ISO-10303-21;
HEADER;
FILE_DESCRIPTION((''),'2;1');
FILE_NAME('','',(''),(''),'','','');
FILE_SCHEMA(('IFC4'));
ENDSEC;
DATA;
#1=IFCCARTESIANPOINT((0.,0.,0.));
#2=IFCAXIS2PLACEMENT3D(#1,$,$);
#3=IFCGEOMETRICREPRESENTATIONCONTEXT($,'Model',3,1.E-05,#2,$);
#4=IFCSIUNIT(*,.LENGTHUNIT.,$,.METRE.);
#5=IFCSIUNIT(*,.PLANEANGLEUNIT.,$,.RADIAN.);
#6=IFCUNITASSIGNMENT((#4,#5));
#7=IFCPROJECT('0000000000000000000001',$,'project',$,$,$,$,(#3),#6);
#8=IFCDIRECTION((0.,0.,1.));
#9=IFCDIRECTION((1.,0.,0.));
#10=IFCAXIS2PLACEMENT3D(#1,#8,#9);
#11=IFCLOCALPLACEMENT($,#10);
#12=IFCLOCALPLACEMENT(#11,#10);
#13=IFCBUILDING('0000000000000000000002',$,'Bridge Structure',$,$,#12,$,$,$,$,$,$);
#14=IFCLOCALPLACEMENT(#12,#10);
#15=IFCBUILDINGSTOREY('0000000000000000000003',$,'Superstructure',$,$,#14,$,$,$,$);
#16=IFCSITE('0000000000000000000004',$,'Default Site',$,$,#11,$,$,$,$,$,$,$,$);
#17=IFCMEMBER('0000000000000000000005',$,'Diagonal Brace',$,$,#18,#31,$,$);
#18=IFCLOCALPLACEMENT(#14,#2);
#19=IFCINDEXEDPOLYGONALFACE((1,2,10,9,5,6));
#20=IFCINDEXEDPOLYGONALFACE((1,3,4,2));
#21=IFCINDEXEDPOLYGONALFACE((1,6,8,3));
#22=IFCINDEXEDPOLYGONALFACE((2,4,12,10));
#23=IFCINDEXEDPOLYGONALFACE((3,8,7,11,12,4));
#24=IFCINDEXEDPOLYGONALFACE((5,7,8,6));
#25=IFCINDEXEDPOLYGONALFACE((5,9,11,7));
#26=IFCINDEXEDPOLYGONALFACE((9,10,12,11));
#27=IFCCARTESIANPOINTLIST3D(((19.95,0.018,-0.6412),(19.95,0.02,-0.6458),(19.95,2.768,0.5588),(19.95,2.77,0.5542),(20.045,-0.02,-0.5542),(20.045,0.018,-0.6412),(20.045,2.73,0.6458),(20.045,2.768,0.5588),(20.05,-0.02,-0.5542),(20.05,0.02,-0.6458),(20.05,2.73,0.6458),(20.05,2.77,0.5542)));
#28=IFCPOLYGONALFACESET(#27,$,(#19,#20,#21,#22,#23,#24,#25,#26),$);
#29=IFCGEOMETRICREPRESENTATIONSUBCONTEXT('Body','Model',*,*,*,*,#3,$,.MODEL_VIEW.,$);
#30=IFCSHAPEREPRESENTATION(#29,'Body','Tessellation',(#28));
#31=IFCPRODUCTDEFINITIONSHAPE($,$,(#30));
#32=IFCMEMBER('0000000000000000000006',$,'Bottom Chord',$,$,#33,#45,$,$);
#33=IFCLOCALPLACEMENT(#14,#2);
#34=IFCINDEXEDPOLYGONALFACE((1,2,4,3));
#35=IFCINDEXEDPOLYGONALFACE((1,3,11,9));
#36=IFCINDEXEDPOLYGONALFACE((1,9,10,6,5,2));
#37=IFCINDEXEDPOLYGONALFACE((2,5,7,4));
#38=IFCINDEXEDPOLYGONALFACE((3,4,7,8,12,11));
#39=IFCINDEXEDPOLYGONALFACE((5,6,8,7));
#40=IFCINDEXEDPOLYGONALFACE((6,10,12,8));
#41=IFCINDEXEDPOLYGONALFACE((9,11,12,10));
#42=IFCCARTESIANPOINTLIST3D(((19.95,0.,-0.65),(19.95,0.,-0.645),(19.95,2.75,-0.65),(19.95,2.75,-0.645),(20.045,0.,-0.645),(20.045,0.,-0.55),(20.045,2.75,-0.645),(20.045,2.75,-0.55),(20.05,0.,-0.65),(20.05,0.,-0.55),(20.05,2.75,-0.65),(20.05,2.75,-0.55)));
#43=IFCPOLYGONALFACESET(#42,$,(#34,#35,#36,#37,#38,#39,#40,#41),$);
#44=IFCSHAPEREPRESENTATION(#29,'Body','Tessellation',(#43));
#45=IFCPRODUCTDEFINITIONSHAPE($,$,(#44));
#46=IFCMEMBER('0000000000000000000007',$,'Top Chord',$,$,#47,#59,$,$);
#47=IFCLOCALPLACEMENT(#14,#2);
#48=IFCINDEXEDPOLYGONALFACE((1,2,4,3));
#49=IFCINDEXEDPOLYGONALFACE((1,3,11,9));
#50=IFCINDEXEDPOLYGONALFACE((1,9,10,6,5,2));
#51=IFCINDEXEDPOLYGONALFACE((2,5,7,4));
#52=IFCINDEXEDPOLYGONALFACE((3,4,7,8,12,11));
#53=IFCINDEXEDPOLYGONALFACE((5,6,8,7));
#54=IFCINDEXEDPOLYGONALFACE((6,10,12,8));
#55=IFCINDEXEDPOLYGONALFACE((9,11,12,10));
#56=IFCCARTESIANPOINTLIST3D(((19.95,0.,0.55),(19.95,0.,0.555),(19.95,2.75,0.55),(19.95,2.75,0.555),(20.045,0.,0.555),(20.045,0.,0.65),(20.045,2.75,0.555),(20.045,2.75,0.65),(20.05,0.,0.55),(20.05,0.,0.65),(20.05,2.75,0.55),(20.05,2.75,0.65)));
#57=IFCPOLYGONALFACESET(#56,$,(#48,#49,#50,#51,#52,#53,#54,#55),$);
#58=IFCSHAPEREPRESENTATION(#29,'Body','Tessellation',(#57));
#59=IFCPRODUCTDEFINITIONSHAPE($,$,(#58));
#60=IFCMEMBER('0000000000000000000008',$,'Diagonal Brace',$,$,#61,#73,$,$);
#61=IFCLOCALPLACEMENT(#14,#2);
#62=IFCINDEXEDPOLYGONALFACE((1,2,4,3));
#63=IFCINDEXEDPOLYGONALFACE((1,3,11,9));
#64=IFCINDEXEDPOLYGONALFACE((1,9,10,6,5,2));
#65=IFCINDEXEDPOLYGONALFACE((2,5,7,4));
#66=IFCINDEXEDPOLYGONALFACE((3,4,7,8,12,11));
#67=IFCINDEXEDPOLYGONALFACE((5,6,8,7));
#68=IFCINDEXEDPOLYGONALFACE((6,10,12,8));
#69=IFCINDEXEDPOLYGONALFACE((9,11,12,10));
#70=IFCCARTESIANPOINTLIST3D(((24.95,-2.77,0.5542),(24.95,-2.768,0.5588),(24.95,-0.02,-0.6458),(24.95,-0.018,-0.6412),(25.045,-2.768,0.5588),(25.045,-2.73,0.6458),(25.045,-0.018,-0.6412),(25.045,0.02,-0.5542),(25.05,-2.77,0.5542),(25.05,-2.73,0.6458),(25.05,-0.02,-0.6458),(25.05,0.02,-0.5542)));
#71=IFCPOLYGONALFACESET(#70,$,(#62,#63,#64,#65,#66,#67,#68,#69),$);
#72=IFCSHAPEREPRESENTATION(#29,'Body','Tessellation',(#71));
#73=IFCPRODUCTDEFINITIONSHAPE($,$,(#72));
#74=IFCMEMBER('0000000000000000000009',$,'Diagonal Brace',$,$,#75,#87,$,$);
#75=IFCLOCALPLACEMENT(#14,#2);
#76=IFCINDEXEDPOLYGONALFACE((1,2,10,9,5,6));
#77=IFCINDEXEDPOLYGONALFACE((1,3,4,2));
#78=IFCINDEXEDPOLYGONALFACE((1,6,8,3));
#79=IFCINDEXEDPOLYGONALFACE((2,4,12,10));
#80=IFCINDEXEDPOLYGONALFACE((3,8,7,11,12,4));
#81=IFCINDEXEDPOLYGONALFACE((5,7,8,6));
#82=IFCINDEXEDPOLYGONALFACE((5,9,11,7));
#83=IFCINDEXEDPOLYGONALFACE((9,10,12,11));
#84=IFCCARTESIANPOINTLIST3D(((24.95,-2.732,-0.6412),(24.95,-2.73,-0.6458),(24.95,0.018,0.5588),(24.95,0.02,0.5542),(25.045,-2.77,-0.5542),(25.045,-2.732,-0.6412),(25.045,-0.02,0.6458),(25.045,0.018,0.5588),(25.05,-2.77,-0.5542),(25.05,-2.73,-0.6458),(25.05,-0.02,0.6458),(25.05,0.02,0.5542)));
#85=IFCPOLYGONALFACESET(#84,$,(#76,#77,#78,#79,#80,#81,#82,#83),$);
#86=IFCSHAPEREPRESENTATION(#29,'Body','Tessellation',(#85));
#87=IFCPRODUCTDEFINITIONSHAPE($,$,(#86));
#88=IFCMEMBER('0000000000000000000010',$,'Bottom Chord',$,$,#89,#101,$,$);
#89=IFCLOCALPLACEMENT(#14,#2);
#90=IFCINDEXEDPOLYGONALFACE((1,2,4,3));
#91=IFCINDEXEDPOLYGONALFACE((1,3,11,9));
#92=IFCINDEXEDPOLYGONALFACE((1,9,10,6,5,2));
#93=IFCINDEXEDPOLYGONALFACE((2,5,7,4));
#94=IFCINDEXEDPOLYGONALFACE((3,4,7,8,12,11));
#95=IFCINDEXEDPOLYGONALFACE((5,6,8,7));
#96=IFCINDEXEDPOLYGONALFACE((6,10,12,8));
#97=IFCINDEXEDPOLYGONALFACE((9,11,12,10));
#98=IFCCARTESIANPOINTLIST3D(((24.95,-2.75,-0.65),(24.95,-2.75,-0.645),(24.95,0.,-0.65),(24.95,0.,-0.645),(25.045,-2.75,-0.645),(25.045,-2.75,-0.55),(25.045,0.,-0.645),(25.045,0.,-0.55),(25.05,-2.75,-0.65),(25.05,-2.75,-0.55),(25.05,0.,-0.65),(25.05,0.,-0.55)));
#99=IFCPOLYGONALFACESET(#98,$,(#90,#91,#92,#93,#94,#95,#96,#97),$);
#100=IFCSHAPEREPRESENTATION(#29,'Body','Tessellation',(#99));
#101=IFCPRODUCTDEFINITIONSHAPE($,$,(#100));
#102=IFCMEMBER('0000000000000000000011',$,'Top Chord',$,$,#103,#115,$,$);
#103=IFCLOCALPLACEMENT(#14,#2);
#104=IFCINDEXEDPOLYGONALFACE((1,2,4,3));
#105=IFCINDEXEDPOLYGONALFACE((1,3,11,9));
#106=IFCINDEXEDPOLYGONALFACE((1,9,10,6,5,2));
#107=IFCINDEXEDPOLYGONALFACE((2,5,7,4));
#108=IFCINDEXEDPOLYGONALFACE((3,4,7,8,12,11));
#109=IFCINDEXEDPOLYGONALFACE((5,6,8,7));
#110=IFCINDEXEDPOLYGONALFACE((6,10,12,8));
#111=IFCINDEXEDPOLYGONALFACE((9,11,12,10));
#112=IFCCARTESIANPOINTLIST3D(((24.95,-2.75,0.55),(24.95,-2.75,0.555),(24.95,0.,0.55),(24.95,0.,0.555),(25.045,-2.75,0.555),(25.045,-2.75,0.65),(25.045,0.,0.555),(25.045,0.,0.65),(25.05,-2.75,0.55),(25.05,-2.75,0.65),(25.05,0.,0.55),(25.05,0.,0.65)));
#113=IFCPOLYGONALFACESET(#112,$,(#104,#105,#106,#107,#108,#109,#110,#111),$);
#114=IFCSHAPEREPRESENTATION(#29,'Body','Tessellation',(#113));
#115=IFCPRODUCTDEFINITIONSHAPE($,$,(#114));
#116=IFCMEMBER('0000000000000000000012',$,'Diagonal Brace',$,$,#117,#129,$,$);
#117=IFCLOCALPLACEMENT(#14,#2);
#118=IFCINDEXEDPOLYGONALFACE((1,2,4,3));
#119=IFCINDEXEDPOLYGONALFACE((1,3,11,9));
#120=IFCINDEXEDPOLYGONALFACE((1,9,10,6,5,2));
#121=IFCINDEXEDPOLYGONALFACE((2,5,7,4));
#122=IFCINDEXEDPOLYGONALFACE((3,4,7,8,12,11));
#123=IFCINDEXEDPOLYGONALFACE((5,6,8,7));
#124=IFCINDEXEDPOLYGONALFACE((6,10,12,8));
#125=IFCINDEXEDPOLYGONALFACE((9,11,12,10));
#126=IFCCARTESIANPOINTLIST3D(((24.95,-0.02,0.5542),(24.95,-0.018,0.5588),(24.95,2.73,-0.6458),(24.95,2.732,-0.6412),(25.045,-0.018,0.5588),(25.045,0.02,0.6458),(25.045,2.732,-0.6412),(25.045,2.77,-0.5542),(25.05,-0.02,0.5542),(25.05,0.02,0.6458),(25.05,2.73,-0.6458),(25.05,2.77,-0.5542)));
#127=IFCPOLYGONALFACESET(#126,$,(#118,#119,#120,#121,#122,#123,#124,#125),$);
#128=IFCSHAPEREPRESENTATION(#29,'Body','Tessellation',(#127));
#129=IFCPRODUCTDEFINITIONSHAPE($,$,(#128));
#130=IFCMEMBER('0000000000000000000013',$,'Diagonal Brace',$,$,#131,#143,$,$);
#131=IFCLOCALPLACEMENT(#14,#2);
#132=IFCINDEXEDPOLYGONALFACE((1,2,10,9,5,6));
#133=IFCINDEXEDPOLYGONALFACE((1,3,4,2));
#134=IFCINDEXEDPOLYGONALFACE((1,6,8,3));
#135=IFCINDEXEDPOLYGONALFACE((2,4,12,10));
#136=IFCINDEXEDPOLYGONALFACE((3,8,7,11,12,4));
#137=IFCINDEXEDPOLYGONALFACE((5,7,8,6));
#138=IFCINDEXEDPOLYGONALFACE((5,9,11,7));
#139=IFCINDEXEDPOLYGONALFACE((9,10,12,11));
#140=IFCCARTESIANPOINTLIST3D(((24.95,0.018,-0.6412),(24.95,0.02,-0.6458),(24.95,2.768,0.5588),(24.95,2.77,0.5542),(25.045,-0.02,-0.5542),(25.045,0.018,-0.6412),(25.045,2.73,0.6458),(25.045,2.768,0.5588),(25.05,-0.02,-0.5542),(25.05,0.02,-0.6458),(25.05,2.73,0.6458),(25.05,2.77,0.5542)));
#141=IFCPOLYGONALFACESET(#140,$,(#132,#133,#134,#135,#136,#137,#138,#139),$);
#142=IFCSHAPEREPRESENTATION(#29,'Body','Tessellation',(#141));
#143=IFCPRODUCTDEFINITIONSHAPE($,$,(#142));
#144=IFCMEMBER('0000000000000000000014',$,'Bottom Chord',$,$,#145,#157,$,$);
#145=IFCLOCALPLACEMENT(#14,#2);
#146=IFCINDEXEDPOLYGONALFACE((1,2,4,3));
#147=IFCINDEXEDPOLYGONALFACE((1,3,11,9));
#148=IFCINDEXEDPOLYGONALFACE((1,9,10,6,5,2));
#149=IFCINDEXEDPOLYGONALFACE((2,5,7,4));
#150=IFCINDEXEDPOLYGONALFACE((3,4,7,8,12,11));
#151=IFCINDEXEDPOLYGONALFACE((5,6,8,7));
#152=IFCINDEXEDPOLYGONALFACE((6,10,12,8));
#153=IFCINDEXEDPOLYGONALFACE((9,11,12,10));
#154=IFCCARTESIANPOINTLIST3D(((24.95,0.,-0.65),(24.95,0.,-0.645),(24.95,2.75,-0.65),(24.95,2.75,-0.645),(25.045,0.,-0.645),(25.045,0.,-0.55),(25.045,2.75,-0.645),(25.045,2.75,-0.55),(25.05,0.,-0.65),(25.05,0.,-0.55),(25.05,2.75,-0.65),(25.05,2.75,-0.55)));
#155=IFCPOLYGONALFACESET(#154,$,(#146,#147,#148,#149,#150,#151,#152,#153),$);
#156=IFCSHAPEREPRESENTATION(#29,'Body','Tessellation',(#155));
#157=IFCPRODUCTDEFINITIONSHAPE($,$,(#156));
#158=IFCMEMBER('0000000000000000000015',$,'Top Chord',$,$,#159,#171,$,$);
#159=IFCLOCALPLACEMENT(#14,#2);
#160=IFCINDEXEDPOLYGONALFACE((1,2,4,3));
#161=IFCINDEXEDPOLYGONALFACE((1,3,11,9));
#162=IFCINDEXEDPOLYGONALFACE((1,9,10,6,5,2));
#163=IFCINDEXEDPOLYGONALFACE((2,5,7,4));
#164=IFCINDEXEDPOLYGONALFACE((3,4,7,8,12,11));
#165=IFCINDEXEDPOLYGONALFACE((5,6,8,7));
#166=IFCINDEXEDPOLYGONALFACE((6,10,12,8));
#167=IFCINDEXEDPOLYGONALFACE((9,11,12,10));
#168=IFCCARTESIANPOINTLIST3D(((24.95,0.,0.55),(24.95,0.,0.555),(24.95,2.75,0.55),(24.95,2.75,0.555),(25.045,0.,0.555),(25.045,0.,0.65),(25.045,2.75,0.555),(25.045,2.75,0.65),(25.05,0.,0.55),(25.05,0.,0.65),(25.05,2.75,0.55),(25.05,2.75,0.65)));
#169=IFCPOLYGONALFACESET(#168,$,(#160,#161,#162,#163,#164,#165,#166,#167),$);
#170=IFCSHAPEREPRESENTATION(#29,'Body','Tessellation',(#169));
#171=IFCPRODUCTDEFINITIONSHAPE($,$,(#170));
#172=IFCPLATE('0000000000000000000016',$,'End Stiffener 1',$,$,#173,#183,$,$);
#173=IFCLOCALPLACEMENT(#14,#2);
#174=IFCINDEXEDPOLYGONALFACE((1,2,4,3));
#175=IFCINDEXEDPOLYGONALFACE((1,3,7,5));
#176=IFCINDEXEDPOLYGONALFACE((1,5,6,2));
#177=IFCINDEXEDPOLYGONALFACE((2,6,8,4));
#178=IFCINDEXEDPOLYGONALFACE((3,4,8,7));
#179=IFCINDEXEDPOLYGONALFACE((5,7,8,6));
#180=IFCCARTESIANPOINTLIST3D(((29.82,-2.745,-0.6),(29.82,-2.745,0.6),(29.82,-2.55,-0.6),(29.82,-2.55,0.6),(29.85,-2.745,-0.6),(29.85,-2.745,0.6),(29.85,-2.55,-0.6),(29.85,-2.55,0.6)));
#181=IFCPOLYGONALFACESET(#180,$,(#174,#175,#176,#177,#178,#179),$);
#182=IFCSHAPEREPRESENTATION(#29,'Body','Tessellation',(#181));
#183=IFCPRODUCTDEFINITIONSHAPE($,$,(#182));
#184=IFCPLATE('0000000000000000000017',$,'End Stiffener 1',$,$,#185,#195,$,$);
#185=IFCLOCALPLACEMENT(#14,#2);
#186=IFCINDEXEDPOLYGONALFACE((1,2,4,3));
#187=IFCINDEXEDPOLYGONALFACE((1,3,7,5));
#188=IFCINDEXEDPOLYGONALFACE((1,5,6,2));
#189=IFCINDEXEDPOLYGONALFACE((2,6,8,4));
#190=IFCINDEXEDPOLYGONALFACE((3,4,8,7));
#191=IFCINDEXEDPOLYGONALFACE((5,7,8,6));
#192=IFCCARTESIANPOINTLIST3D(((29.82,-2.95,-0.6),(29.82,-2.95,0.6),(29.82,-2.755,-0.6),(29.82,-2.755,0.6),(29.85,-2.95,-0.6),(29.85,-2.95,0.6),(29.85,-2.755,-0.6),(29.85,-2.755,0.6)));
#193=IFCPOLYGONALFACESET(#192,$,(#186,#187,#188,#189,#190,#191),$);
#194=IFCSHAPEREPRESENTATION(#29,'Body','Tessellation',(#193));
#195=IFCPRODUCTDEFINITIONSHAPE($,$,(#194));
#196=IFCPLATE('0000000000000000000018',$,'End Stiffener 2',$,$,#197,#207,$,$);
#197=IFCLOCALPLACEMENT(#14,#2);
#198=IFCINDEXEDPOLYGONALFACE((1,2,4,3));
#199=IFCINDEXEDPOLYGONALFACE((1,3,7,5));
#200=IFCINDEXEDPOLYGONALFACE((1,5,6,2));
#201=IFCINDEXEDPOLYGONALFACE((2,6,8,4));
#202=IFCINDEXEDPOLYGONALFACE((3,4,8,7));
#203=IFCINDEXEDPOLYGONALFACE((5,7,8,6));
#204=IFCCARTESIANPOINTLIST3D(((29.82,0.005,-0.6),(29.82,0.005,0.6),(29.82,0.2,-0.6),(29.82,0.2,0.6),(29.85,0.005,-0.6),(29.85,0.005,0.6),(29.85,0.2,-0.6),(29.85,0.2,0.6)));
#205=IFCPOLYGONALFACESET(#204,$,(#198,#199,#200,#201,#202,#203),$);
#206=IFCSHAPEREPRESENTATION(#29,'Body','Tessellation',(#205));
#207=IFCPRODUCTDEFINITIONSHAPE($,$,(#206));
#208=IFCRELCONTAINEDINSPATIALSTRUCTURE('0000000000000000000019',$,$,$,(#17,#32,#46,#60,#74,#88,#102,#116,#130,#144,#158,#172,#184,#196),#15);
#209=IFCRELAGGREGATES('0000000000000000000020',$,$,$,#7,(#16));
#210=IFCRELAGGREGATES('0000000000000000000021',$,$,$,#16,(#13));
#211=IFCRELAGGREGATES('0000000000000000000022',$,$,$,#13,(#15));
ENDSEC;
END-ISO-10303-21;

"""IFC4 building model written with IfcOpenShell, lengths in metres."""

from ifc_helpers import new_model, si_unit, frame, origin, origin_with_axes, origin_2d_with_axis, place, context, subcontext, project, spatial, rectangle, l_section, extrude, element, save


model = new_model("IFC4")

# Units and contexts
model_context = context("Model", 3, precision=1e-05, world=origin())
body_context = subcontext(model_context, "Body", "Model", "MODEL_VIEW")
ifc_project = project(units=[si_unit("LENGTHUNIT", "METRE"), si_unit("PLANEANGLEUNIT", "RADIAN")], contexts=[model_context])

# Site, building, storey
site_placement = place(None, origin_with_axes())
site = spatial("IfcSite", under=ifc_project, at=site_placement, Name="Default Site")
building_placement = place(site_placement, origin_with_axes())
building = spatial("IfcBuilding", under=site, at=building_placement, Name="Bridge Structure")
storey_placement = place(building_placement, origin_with_axes())
storey = spatial("IfcBuildingStorey", under=building, at=storey_placement, Name="Superstructure")

# Members
for number, where, z_axis, x_axis, name in (
    (1, (20.0, 0.0, -0.6), (0.0, 0.916539, 0.399944), (-1.0, 0.0, 0.0), "Diagonal Brace"),
):
    element("IfcMember", number, at=place(storey_placement, frame(where, z_axis=z_axis, x_axis=x_axis)), inside=storey, Name=name, context=body_context, shape_type="SweptSolid", body=[
        extrude(l_section(Depth=0.1, Width=0.1, Thickness=0.005, at=origin_2d_with_axis()), origin_with_axes(), (0.0, 0.0, 1.0), 3.0004),
    ])
for number, where, z_axis, x_axis, name in (
    (2, (20.0, 0.0, -0.6), (0.0, 1.0, 0.0), (-1.0, 0.0, 0.0), "Bottom Chord"),
    (3, (20.0, 0.0, 0.6), (0.0, 1.0, 0.0), (-1.0, 0.0, 0.0), "Top Chord"),
):
    element("IfcMember", number, at=place(storey_placement, frame(where, z_axis=z_axis, x_axis=x_axis)), inside=storey, Name=name, context=body_context, shape_type="SweptSolid", body=[
        extrude(l_section(Depth=0.1, Width=0.1, Thickness=0.005, at=origin_2d_with_axis()), origin_with_axes(), (0.0, 0.0, 1.0), 2.75),
    ])
for number, where, z_axis, x_axis, name in (
    (4, (25.0, -2.75, 0.6), (0.0, 0.916539, -0.399944), (-1.0, 0.0, 0.0), "Diagonal Brace"),
    (5, (25.0, -2.75, -0.6), (0.0, 0.916539, 0.399944), (-1.0, 0.0, 0.0), "Diagonal Brace"),
):
    element("IfcMember", number, at=place(storey_placement, frame(where, z_axis=z_axis, x_axis=x_axis)), inside=storey, Name=name, context=body_context, shape_type="SweptSolid", body=[
        extrude(l_section(Depth=0.1, Width=0.1, Thickness=0.005, at=origin_2d_with_axis()), origin_with_axes(), (0.0, 0.0, 1.0), 3.0004),
    ])
for number, where, z_axis, x_axis, name in (
    (6, (25.0, -2.75, -0.6), (0.0, 1.0, 0.0), (-1.0, 0.0, 0.0), "Bottom Chord"),
    (7, (25.0, -2.75, 0.6), (0.0, 1.0, 0.0), (-1.0, 0.0, 0.0), "Top Chord"),
):
    element("IfcMember", number, at=place(storey_placement, frame(where, z_axis=z_axis, x_axis=x_axis)), inside=storey, Name=name, context=body_context, shape_type="SweptSolid", body=[
        extrude(l_section(Depth=0.1, Width=0.1, Thickness=0.005, at=origin_2d_with_axis()), origin_with_axes(), (0.0, 0.0, 1.0), 2.75),
    ])
for number, where, z_axis, x_axis, name in (
    (8, (25.0, 0.0, 0.6), (0.0, 0.916539, -0.399944), (-1.0, 0.0, 0.0), "Diagonal Brace"),
    (9, (25.0, 0.0, -0.6), (0.0, 0.916539, 0.399944), (-1.0, 0.0, 0.0), "Diagonal Brace"),
):
    element("IfcMember", number, at=place(storey_placement, frame(where, z_axis=z_axis, x_axis=x_axis)), inside=storey, Name=name, context=body_context, shape_type="SweptSolid", body=[
        extrude(l_section(Depth=0.1, Width=0.1, Thickness=0.005, at=origin_2d_with_axis()), origin_with_axes(), (0.0, 0.0, 1.0), 3.0004),
    ])
for number, where, z_axis, x_axis, name in (
    (10, (25.0, 0.0, -0.6), (0.0, 1.0, 0.0), (-1.0, 0.0, 0.0), "Bottom Chord"),
    (11, (25.0, 0.0, 0.6), (0.0, 1.0, 0.0), (-1.0, 0.0, 0.0), "Top Chord"),
):
    element("IfcMember", number, at=place(storey_placement, frame(where, z_axis=z_axis, x_axis=x_axis)), inside=storey, Name=name, context=body_context, shape_type="SweptSolid", body=[
        extrude(l_section(Depth=0.1, Width=0.1, Thickness=0.005, at=origin_2d_with_axis()), origin_with_axes(), (0.0, 0.0, 1.0), 2.75),
    ])

# Plates
for number, where, z_axis, x_axis, name in (
    (12, (29.835, -2.6475, -0.6), (0.0, 0.0, 1.0), (1.0, 0.0, 0.0), "End Stiffener 1"),
    (13, (29.835, -2.8525, -0.6), (0.0, 0.0, 1.0), (1.0, 0.0, 0.0), "End Stiffener 1"),
    (14, (29.835, 0.1025, -0.6), (0.0, 0.0, 1.0), (1.0, 0.0, 0.0), "End Stiffener 2"),
):
    element("IfcPlate", number, at=place(storey_placement, frame(where, z_axis=z_axis, x_axis=x_axis)), inside=storey, Name=name, context=body_context, shape_type="SweptSolid", body=[
        extrude(rectangle(XDim=0.03, YDim=0.195, at=origin_2d_with_axis()), origin_with_axes(), (0.0, 0.0, 1.0), 1.2),
    ])

save(model, "model.ifc")
